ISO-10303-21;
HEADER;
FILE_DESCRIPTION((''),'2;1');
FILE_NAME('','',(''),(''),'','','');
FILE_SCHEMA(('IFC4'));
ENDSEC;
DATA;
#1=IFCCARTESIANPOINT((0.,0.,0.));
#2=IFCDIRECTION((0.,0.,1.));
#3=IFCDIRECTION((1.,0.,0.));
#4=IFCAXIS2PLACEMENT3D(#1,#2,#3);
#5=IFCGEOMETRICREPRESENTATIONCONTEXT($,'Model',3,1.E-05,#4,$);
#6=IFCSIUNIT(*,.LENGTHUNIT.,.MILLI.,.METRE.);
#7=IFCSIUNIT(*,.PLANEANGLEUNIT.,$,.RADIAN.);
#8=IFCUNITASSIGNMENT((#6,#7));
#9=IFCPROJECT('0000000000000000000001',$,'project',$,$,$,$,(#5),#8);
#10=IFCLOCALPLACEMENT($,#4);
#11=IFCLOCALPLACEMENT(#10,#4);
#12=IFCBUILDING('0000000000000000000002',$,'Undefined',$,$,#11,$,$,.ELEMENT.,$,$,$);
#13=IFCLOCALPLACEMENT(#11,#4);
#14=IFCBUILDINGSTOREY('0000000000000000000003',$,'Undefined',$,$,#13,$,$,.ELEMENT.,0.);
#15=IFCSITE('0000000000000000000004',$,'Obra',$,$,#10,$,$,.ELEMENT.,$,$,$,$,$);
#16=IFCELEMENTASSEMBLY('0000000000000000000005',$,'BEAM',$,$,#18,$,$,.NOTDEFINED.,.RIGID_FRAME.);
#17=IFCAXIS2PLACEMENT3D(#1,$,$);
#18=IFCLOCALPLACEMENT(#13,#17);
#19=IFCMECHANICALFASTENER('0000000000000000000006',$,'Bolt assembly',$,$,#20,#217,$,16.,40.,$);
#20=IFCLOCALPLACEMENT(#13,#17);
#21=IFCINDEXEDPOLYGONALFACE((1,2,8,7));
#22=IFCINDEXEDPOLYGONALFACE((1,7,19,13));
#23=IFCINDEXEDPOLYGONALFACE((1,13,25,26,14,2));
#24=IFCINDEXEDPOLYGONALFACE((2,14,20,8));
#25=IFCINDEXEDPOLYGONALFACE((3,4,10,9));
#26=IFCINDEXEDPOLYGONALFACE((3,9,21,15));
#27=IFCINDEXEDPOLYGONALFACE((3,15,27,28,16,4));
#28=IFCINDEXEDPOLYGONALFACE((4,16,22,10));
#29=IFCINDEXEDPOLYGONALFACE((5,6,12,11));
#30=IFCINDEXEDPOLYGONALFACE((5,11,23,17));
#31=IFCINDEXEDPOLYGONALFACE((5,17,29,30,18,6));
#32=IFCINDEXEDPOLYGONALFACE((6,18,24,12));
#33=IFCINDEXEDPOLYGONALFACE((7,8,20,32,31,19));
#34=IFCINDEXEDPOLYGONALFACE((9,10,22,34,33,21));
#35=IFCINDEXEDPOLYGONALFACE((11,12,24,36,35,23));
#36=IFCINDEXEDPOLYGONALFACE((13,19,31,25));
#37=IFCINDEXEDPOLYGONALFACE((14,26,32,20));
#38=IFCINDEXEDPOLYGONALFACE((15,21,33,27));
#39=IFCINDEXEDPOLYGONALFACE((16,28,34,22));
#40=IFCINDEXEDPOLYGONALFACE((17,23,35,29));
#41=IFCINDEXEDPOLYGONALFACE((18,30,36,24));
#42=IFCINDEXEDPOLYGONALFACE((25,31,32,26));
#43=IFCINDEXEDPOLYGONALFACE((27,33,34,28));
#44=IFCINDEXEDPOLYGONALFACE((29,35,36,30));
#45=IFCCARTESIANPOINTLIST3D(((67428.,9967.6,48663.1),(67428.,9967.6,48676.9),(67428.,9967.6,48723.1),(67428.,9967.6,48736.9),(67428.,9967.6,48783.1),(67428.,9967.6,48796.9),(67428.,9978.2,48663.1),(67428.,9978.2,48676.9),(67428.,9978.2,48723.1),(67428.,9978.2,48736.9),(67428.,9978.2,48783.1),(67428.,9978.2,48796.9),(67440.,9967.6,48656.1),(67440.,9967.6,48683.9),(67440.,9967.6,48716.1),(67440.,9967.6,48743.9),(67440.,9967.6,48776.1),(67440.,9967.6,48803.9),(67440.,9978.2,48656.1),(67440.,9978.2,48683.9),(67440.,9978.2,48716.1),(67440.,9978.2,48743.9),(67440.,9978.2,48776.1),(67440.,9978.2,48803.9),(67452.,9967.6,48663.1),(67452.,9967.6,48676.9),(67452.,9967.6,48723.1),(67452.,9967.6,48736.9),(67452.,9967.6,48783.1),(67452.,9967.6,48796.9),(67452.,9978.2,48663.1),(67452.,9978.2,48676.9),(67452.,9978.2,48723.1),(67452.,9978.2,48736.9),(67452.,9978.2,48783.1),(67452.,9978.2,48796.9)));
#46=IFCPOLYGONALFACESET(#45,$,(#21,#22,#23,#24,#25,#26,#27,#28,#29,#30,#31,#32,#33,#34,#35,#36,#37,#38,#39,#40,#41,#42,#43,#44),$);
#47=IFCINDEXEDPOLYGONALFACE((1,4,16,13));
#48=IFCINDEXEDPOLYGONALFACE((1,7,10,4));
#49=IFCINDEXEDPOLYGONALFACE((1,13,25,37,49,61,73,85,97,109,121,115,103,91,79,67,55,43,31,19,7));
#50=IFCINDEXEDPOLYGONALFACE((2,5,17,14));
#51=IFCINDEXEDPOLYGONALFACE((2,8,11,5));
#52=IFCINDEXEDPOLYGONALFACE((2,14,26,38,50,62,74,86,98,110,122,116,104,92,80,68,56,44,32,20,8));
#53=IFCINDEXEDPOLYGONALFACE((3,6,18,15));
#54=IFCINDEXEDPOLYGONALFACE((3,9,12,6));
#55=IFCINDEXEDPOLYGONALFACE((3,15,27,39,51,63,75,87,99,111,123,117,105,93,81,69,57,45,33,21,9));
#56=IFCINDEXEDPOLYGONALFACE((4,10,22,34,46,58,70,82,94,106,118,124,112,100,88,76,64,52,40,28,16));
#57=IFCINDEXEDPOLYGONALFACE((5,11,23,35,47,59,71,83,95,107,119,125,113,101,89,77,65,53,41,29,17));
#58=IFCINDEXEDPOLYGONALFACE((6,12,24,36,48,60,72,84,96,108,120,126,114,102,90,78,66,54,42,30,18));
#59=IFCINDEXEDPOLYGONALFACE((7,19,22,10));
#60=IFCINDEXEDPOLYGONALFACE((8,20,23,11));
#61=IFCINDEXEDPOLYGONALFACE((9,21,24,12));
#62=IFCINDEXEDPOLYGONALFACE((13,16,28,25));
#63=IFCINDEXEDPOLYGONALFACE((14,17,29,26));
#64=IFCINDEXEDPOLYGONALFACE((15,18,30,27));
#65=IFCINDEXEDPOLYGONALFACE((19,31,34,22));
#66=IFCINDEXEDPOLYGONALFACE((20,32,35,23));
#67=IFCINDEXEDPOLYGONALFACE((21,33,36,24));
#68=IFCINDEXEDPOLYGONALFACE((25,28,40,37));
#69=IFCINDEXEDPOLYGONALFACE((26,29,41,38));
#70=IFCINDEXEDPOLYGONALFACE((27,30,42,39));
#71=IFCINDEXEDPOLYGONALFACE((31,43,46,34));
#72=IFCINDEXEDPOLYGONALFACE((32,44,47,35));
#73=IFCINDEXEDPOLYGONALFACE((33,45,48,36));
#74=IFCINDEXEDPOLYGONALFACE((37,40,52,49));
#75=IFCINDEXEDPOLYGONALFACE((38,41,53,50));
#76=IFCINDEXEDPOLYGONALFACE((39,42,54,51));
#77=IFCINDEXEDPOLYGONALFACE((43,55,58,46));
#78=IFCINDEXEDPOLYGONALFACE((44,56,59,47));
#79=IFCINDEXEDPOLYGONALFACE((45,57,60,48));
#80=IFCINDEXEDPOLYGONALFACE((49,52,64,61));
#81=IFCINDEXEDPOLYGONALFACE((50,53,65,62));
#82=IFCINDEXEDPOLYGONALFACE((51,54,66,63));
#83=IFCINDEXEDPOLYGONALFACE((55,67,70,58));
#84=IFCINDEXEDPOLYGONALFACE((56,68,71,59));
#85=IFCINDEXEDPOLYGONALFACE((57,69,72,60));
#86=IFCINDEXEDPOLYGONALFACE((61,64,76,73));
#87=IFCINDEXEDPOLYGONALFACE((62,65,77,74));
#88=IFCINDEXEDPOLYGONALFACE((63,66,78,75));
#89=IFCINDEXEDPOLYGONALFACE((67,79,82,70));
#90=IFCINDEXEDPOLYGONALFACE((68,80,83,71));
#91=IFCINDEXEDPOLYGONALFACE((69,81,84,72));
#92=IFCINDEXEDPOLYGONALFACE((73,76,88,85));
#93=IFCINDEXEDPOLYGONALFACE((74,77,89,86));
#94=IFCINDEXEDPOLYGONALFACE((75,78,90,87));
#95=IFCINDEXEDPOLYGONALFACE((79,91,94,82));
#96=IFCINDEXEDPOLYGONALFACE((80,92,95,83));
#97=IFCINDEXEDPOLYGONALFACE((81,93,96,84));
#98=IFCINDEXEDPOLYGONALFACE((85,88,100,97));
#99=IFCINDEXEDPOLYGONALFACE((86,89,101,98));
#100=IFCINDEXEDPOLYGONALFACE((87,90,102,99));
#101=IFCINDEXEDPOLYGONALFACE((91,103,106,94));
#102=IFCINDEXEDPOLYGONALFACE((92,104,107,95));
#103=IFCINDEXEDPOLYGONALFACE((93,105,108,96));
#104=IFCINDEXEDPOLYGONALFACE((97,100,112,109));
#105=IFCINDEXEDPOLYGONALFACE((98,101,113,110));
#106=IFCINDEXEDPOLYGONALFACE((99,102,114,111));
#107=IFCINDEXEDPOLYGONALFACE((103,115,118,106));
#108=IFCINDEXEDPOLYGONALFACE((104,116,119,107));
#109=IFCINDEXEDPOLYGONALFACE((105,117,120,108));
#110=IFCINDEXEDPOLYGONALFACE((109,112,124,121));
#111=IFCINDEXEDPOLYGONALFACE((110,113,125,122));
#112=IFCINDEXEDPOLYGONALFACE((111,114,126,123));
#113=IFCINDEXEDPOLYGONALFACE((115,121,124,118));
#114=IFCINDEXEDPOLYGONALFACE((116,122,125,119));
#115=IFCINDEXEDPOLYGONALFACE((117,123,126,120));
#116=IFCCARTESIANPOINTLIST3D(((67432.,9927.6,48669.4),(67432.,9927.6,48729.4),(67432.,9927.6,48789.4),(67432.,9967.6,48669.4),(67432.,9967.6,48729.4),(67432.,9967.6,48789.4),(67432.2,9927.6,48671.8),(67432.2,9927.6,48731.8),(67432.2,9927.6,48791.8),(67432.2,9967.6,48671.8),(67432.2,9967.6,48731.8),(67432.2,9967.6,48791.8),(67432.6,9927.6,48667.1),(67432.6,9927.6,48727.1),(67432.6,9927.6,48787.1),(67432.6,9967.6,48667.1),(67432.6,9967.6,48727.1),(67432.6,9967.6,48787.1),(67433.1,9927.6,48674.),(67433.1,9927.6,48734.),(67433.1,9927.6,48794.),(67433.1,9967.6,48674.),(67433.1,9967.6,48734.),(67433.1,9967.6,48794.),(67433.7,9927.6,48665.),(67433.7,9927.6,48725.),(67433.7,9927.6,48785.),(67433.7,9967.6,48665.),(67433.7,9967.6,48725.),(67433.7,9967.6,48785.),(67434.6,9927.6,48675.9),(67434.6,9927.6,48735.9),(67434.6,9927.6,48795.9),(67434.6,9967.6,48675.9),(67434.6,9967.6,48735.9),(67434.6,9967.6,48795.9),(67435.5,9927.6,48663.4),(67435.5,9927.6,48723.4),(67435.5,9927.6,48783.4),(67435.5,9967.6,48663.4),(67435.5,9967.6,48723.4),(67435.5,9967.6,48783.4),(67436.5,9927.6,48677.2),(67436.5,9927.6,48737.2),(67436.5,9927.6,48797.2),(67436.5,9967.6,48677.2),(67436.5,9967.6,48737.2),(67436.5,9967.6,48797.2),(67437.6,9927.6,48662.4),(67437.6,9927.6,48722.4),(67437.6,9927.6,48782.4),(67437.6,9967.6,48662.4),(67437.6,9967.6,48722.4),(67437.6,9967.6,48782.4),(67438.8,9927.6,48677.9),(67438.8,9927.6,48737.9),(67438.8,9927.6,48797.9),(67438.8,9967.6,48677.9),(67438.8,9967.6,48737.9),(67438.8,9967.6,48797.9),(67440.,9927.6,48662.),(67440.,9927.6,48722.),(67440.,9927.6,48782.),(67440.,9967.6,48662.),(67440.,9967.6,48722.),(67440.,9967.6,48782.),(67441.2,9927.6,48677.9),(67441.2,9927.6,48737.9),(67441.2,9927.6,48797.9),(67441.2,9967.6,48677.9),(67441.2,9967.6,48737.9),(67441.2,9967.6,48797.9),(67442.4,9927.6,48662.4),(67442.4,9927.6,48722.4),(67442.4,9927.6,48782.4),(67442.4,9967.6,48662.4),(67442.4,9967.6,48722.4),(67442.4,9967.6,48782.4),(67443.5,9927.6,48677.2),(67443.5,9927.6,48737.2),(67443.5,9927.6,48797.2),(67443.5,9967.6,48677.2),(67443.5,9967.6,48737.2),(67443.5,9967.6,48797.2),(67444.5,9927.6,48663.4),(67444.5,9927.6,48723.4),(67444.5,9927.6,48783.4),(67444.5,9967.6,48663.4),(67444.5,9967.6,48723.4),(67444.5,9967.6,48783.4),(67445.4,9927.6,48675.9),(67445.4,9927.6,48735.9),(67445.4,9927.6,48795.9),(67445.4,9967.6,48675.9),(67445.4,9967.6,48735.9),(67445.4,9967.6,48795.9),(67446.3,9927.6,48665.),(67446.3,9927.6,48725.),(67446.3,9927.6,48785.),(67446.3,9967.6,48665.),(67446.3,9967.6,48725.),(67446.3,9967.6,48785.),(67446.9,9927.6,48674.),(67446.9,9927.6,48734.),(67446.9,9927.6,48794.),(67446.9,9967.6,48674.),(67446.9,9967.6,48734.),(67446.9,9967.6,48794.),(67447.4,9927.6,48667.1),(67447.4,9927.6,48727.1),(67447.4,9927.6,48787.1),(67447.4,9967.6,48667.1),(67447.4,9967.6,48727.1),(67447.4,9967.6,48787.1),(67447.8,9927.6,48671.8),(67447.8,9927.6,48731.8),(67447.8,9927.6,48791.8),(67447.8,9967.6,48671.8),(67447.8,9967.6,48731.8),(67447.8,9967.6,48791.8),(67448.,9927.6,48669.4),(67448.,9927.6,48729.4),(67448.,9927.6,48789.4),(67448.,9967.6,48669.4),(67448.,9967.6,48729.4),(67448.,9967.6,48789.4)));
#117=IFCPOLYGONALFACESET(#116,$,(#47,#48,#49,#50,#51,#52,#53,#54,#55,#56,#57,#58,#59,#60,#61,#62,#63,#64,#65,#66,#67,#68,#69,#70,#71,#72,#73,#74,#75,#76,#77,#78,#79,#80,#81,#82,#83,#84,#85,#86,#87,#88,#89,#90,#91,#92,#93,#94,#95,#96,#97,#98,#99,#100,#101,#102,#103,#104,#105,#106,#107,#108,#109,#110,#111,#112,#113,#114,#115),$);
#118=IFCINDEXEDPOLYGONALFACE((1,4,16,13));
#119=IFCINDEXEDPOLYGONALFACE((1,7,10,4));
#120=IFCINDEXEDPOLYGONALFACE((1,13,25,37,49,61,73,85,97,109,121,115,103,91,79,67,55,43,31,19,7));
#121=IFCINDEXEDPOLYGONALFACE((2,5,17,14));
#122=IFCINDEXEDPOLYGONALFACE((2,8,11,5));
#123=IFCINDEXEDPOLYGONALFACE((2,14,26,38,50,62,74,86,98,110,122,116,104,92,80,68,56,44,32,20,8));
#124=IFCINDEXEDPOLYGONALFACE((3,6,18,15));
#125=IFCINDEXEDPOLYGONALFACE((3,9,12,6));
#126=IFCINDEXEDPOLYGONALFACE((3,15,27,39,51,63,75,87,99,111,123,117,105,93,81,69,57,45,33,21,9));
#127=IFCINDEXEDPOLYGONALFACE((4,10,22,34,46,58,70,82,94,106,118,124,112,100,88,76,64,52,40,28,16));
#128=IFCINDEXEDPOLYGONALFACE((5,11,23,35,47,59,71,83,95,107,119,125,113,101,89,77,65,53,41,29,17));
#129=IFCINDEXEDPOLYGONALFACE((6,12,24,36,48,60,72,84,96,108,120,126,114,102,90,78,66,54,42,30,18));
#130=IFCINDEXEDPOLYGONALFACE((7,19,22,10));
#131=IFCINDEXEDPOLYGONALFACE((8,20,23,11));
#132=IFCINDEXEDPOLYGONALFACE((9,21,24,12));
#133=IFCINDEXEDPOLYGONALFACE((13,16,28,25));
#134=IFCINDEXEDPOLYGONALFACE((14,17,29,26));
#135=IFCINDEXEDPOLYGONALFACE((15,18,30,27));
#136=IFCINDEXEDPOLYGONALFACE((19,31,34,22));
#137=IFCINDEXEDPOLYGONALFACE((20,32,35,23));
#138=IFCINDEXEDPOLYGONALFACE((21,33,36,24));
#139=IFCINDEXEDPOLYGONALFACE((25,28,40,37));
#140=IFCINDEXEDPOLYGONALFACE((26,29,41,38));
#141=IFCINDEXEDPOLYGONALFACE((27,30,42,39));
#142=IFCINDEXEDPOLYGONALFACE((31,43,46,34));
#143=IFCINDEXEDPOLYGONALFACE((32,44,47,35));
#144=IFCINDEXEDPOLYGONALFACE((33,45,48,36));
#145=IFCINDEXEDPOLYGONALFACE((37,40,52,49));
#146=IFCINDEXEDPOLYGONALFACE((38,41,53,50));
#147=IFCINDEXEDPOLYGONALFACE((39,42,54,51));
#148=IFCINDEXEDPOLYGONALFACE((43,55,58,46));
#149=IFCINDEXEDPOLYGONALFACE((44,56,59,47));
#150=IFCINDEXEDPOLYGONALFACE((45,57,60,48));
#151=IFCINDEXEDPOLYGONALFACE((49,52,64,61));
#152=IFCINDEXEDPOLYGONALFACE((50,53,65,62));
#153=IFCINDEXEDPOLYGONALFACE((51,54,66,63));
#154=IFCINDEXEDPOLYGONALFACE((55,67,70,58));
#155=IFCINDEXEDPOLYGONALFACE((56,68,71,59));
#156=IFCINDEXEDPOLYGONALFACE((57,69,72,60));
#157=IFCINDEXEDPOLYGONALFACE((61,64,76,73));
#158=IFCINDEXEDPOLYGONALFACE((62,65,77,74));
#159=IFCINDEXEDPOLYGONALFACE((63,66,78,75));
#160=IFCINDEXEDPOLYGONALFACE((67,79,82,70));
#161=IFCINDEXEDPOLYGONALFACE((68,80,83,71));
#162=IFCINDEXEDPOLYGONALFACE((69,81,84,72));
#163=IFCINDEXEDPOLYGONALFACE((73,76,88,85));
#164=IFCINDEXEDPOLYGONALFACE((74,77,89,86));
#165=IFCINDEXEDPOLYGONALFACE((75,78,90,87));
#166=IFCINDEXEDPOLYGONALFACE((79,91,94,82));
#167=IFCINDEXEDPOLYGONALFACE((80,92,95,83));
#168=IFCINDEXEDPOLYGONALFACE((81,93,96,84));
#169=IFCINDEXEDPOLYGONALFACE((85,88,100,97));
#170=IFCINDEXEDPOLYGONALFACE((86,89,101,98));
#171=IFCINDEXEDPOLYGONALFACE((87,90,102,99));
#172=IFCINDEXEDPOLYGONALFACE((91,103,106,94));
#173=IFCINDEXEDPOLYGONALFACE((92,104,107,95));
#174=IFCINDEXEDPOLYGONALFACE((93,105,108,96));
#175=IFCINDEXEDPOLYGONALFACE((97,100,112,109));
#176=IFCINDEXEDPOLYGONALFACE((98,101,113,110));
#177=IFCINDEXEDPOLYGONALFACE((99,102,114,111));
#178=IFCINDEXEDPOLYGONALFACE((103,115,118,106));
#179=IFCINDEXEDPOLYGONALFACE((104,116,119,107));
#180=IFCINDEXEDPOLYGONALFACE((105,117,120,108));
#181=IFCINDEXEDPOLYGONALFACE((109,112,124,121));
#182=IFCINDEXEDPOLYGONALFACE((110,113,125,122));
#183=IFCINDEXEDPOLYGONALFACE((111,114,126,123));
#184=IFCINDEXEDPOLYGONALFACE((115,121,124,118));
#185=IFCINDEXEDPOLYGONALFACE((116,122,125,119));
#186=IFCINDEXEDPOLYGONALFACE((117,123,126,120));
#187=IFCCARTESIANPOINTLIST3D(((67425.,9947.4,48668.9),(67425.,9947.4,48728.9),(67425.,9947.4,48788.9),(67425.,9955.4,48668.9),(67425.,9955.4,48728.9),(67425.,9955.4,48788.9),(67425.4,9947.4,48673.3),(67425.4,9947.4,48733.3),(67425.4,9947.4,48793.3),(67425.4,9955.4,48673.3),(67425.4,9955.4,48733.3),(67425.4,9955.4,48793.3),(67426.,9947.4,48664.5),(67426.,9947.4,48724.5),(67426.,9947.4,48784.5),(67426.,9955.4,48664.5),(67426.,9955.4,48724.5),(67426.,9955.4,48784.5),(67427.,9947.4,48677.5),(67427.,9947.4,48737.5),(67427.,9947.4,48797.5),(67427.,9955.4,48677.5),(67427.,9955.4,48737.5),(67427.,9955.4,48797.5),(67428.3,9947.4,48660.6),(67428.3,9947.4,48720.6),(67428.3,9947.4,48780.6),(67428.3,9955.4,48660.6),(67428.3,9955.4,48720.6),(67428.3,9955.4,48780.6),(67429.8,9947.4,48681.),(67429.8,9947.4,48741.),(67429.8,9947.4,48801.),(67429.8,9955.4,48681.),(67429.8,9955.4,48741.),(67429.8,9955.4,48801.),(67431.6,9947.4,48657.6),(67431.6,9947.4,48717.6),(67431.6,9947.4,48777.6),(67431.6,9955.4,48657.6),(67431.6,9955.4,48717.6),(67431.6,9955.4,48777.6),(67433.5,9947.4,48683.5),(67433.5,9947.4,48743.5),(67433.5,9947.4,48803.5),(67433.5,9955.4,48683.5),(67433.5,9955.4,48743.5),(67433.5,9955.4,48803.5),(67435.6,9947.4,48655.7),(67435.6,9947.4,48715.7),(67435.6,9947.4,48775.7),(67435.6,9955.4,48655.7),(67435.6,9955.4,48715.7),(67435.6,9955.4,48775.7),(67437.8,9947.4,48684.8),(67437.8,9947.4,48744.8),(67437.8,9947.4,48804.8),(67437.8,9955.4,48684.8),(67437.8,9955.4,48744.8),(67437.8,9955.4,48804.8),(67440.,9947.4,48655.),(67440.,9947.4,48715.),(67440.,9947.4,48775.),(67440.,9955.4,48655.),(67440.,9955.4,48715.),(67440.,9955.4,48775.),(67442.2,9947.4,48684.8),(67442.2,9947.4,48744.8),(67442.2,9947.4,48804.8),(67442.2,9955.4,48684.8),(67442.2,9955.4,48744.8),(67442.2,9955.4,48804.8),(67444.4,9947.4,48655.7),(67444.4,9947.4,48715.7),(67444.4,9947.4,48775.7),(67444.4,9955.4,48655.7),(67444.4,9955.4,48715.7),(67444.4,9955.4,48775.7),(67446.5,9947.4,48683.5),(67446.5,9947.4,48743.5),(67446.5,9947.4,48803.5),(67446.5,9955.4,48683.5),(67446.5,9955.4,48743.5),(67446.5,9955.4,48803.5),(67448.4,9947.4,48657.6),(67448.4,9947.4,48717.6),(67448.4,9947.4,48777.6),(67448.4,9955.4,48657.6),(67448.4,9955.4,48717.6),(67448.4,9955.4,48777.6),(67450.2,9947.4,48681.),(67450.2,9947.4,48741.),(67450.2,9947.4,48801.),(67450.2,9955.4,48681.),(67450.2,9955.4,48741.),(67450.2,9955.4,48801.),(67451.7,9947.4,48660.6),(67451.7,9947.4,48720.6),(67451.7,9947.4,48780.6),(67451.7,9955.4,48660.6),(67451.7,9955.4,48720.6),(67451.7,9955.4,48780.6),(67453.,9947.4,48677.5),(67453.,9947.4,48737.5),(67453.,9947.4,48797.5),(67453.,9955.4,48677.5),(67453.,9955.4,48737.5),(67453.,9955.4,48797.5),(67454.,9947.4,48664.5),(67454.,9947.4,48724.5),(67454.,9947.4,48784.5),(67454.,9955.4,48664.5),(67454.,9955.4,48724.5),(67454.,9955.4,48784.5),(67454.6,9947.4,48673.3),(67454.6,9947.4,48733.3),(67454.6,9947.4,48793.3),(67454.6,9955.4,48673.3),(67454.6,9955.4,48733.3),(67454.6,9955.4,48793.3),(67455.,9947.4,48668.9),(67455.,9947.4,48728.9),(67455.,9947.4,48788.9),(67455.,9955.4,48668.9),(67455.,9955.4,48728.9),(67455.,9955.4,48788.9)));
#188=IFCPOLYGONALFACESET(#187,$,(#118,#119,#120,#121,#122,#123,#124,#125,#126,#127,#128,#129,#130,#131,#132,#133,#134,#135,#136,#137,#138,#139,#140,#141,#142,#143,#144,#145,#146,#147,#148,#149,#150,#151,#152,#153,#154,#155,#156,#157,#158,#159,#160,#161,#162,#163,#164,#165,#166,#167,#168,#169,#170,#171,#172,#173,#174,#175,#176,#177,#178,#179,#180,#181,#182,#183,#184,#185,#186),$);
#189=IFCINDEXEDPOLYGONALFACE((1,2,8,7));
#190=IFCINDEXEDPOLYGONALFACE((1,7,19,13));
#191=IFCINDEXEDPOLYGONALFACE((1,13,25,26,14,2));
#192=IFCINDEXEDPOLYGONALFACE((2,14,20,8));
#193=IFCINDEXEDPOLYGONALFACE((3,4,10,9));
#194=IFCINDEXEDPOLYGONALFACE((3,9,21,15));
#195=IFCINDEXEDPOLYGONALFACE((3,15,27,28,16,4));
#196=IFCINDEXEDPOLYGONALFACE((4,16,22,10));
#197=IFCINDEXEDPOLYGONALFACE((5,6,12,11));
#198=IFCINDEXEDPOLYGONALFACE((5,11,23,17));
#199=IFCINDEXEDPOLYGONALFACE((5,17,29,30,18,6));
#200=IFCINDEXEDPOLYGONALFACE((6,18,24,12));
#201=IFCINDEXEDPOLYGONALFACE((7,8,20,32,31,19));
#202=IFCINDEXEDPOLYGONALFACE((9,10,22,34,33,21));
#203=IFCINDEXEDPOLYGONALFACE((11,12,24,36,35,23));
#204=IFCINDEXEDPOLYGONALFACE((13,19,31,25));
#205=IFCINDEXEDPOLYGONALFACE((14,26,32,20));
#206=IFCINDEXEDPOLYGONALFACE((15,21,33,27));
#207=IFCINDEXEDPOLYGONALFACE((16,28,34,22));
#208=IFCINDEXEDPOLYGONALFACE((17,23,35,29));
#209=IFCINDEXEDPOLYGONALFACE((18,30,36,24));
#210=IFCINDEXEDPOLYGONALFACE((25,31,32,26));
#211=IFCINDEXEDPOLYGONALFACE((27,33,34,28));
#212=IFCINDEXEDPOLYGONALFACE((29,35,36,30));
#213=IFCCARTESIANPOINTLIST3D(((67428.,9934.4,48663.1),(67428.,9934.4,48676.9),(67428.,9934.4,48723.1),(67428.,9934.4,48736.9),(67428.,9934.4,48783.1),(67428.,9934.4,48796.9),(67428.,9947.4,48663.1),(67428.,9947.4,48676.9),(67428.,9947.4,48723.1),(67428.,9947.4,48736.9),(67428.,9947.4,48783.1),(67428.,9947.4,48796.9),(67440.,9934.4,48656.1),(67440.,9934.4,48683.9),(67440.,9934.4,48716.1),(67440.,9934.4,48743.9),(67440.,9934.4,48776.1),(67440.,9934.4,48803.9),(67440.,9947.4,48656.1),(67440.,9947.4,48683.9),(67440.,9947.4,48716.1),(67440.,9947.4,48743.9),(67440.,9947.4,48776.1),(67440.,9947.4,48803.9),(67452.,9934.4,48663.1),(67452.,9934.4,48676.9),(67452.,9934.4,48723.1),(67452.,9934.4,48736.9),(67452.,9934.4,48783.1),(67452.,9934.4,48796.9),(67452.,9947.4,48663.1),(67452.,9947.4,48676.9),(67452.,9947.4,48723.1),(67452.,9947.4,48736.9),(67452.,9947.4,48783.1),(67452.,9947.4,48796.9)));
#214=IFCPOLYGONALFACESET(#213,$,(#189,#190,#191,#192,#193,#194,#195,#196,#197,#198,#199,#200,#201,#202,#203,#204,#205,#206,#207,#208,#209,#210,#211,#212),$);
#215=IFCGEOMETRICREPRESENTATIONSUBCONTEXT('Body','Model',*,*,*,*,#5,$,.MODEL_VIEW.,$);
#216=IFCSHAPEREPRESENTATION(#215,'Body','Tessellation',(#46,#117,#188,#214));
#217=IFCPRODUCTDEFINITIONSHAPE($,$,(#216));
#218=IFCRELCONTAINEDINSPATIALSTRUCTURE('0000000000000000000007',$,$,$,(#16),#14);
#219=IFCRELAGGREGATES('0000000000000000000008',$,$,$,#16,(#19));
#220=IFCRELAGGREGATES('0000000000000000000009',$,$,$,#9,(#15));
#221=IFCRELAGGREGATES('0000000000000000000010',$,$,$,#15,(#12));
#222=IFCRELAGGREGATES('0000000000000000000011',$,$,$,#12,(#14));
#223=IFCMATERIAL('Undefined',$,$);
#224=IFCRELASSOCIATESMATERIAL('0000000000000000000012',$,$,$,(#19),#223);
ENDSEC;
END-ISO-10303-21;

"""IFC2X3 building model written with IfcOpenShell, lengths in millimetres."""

from ifc_helpers import new_model, si_unit, frame, origin_with_axes, origin_2d_with_axis, place, context, subcontext, project, spatial, polyline, circle, outline, extrude, source, transform, mapped, material, element, aggregate, save


model = new_model("IFC2X3")

# Units and contexts
model_context = context("Model", 3, precision=1e-05, world=origin_with_axes())
body_context = subcontext(model_context, "Body", "Model", "MODEL_VIEW")
ifc_project = project(units=[si_unit("LENGTHUNIT", "METRE", prefix="MILLI"), si_unit("PLANEANGLEUNIT", "RADIAN")], contexts=[model_context])

# Site, building, storey
site_placement = place(None, origin_with_axes())
site = spatial("IfcSite", under=ifc_project, at=site_placement, Name="Obra", CompositionType="ELEMENT")
building_placement = place(site_placement, origin_with_axes())
building = spatial("IfcBuilding", under=site, at=building_placement, Name="Undefined", CompositionType="ELEMENT")
storey_placement = place(building_placement, origin_with_axes())
storey = spatial("IfcBuildingStorey", under=building, at=storey_placement, Name="Undefined", CompositionType="ELEMENT", Elevation=0.0)

# Element assembly, mechanical fastener
assembly_1_placement = place(storey_placement, origin_with_axes())
assembly_1 = element("IfcElementAssembly", 1, at=assembly_1_placement, inside=storey, Name="BEAM", AssemblyPlace="NOTDEFINED", PredefinedType="RIGID_FRAME")
ifc_material_1 = material(Name="Undefined")
shared_shape_1 = source(origin_with_axes(), body_context, "Body", "SweptSolid", [
    extrude(outline(polyline([(13.9, 0.0), (6.9, 12.0), (-6.9, 12.0), (-13.9, 0.0), (-6.9, -12.0), (6.9, -12.0), (13.9, 0.0)])), frame((0.0, -19.7, 0.0), z_axis=(0.0, 1.0, 0.0), x_axis=(1.0, 0.0, 0.0)), (0.0, 0.0, 1.0), 10.6),
    extrude(circle(Radius=8.0, at=origin_2d_with_axis()), frame((0.0, -9.1, 0.0), z_axis=(0.0, 1.0, 0.0), x_axis=(1.0, 0.0, 0.0)), (0.0, 0.0, 1.0), 40.0),
    extrude(circle(Radius=15.0, at=origin_2d_with_axis()), frame((0.0, 3.1, 0.0), z_axis=(0.0, 1.0, 0.0), x_axis=(1.0, 0.0, 0.0)), (0.0, 0.0, 1.0), 8.0),
    extrude(outline(polyline([(13.9, 0.0), (6.9, 12.0), (-6.9, 12.0), (-13.9, 0.0), (-6.9, -12.0), (6.9, -12.0), (13.9, 0.0)])), frame((0.0, 11.1, 0.0), z_axis=(0.0, 1.0, 0.0), x_axis=(1.0, 0.0, 0.0)), (0.0, 0.0, 1.0), 13.0),
])
mechanical_fastener_1_placement = place(assembly_1_placement, frame((67490.0, 9958.5, 48850.0), z_axis=(-1.0, 0.0, 0.0), x_axis=(0.0, 0.0, -1.0)))
mechanical_fastener_1 = element("IfcMechanicalFastener", 2, at=mechanical_fastener_1_placement, material=ifc_material_1, Name="Bolt assembly", NominalDiameter=16.0, NominalLength=40.0, context=body_context, shape_type="MappedRepresentation", body=[
    mapped(shared_shape_1, transform((60.0, 0.0, 50.0))),
    mapped(shared_shape_1, transform((120.0, 0.0, 50.0))),
    mapped(shared_shape_1, transform((180.0, 0.0, 50.0))),
])
aggregate(assembly_1, [mechanical_fastener_1])

save(model, "model.ifc")
